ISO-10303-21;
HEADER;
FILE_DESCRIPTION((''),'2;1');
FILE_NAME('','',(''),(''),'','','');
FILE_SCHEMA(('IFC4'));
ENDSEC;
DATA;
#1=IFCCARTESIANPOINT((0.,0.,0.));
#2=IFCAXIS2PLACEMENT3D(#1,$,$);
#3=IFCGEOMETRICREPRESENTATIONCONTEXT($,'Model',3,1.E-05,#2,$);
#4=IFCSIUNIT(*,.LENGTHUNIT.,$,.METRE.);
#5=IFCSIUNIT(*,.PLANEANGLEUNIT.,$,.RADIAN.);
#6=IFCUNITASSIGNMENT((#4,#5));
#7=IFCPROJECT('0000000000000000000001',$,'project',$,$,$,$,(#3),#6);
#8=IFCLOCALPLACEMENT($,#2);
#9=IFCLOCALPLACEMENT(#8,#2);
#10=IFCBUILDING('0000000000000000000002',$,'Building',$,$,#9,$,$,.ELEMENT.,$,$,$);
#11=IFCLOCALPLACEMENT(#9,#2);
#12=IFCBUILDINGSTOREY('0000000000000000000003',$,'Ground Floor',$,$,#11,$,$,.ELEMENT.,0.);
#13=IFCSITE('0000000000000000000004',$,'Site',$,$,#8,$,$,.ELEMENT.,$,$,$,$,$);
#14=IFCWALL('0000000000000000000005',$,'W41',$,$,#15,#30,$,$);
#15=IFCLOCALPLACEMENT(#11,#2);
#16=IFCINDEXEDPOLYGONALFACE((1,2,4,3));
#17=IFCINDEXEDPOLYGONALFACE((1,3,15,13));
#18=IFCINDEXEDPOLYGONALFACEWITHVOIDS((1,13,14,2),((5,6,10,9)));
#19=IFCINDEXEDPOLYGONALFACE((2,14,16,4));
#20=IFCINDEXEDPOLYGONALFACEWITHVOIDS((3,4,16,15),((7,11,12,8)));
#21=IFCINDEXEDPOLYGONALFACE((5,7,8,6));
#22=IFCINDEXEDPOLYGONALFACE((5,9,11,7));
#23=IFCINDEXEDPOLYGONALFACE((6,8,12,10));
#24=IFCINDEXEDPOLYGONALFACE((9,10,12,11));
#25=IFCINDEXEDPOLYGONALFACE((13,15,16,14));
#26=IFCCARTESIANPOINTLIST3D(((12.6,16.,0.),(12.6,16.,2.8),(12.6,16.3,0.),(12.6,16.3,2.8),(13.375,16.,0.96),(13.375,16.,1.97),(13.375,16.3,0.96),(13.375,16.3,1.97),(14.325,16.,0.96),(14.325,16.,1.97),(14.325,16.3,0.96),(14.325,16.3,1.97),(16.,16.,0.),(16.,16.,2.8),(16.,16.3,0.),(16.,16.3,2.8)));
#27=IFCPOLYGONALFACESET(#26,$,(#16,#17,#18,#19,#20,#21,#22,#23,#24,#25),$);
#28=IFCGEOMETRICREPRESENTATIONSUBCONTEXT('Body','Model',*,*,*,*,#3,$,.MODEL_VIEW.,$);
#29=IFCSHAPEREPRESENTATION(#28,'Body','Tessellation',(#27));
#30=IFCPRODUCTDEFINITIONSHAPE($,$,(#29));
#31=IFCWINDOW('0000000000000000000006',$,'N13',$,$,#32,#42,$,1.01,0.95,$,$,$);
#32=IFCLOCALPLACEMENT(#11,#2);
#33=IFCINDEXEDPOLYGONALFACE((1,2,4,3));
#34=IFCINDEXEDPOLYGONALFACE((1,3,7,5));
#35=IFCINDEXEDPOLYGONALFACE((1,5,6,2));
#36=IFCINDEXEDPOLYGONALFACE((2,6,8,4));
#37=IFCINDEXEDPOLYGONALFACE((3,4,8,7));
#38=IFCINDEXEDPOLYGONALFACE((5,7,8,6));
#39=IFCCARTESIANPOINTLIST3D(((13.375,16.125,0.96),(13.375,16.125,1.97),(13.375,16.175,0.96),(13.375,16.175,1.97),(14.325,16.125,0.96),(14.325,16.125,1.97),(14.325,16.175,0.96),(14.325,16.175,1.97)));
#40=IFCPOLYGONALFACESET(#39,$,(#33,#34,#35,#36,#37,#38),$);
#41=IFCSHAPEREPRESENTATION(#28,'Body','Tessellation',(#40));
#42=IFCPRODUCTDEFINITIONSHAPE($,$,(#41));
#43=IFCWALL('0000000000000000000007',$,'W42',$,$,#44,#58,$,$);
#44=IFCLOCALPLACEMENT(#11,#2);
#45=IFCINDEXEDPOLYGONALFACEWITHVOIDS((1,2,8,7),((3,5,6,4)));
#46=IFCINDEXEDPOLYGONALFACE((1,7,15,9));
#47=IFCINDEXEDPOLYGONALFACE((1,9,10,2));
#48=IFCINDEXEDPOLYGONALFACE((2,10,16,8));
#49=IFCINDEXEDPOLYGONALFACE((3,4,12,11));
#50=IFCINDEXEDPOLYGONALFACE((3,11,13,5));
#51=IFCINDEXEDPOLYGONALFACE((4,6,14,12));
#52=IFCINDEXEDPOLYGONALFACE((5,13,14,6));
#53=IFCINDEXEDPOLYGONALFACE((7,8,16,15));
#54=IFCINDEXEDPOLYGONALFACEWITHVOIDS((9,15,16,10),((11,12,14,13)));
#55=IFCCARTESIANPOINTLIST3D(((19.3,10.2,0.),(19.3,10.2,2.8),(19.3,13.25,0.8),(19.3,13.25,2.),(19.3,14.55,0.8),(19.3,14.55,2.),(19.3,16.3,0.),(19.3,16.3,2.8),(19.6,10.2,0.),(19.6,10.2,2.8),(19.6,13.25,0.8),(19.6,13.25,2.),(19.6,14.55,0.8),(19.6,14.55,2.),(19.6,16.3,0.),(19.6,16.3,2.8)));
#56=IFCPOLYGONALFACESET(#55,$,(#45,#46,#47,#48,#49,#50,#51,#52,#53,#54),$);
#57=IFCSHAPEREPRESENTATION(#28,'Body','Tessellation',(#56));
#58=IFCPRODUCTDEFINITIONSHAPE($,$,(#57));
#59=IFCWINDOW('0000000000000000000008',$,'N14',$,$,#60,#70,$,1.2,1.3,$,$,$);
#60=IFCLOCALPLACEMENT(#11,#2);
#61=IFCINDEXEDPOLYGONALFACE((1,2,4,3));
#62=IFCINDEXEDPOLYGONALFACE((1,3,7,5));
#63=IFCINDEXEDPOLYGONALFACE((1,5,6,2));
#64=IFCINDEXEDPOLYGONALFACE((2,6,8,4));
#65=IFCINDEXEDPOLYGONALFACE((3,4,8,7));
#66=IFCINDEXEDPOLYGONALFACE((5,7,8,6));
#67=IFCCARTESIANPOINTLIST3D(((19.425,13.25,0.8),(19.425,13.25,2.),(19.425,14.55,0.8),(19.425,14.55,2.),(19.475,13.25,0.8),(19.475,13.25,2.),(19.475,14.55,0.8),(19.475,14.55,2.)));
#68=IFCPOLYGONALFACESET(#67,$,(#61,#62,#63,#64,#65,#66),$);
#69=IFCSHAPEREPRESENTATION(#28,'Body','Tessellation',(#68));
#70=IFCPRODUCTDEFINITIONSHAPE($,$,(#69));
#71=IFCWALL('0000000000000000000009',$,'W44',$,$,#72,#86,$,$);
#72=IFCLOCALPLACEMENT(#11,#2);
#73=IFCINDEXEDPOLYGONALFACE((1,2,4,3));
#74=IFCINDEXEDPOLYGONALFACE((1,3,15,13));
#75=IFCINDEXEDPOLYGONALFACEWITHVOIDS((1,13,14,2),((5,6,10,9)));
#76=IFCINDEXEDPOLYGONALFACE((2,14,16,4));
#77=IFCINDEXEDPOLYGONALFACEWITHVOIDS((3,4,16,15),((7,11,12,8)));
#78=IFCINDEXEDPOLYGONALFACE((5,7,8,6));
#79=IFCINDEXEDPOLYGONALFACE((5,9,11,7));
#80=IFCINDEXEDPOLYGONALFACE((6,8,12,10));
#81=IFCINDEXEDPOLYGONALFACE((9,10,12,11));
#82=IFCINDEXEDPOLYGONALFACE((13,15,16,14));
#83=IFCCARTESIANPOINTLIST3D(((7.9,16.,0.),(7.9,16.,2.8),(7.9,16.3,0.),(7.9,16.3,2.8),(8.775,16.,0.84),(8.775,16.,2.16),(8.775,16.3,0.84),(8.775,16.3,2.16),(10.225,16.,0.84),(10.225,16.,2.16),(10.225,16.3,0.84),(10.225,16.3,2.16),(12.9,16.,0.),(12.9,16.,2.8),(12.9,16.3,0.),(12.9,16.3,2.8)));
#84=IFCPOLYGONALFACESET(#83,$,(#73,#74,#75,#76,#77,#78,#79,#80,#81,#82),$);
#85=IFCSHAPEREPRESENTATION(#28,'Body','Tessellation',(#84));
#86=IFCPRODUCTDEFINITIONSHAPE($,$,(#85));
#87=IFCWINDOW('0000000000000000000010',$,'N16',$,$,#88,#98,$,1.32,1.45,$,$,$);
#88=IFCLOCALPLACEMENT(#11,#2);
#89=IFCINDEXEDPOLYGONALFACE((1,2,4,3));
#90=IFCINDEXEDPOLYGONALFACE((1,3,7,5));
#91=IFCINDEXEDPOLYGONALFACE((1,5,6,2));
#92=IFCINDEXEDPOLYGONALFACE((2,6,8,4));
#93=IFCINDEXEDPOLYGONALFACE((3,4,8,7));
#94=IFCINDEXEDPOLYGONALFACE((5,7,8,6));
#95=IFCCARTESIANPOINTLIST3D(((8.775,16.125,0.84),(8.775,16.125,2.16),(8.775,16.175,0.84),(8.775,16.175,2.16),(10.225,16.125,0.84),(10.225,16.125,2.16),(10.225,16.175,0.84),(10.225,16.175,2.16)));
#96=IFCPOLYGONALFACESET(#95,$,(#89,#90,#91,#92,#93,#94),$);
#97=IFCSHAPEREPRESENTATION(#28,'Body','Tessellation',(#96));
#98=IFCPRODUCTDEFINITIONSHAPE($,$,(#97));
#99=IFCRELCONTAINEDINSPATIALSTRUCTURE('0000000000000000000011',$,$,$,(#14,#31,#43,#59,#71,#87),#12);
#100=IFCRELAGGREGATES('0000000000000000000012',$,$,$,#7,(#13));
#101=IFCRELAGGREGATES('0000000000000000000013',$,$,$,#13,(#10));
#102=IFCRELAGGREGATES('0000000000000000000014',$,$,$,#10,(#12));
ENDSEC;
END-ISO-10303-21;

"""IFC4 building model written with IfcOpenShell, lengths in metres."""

from ifc_helpers import new_model, si_unit, frame, frame_2d, origin, origin_2d, place, context, subcontext, project, spatial, rectangle, extrude, element, fill, save


model = new_model("IFC4")

# Units and contexts
model_context = context("Model", 3, precision=1e-05, world=origin())
body_context = subcontext(model_context, "Body", "Model", "MODEL_VIEW")
ifc_project = project(units=[si_unit("LENGTHUNIT", "METRE"), si_unit("PLANEANGLEUNIT", "RADIAN")], contexts=[model_context])

# Site, building, storey
site_placement = place(None, origin())
site = spatial("IfcSite", under=ifc_project, at=site_placement, Name="Site", CompositionType="ELEMENT")
building_placement = place(site_placement, origin())
building = spatial("IfcBuilding", under=site, at=building_placement, Name="Building", CompositionType="ELEMENT")
storey_placement = place(building_placement, origin())
storey = spatial("IfcBuildingStorey", under=building, at=storey_placement, Name="Ground Floor", CompositionType="ELEMENT", Elevation=0.0)

# Walls, openings, windows
wall_1_placement = place(storey_placement, frame((12.75, 16.15, 0.0), x_axis=(1.0, 0.0, 0.0)))
wall_1 = element("IfcWall", 1, at=wall_1_placement, inside=storey, Name="W41", context=body_context, shape_type="SweptSolid", body=[
    extrude(rectangle(XDim=3.4, YDim=0.3, at=frame_2d((1.55, 0.0))), origin(), (0.0, 0.0, 1.0), 2.8),
])
opening_1_placement = place(wall_1_placement, frame((1.1, 0.0, 0.96)))
opening_1 = element("IfcOpeningElement", 2, at=opening_1_placement, cuts=wall_1, context=body_context, shape_type="SweptSolid", body=[
    extrude(rectangle(XDim=0.95, YDim=0.4, at=origin_2d()), origin(), (0.0, 0.0, 1.0), 1.01),
])
window_1_placement = place(opening_1_placement, origin())
window_1 = element("IfcWindow", 3, at=window_1_placement, inside=storey, Name="N13", OverallHeight=1.01, OverallWidth=0.95, context=body_context, shape_type="SweptSolid", body=[
    extrude(rectangle(XDim=0.95, YDim=0.05, at=origin_2d()), origin(), (0.0, 0.0, 1.0), 1.01),
])
fill(opening_1, window_1)
wall_2_placement = place(storey_placement, frame((19.45, 10.35, 0.0), x_axis=(0.0, 1.0, 0.0)))
wall_2 = element("IfcWall", 4, at=wall_2_placement, inside=storey, Name="W42", context=body_context, shape_type="SweptSolid", body=[
    extrude(rectangle(XDim=6.1, YDim=0.3, at=frame_2d((2.9, 0.0))), origin(), (0.0, 0.0, 1.0), 2.8),
])
opening_2_placement = place(wall_2_placement, frame((3.55, 0.0, 0.8)))
opening_2 = element("IfcOpeningElement", 5, at=opening_2_placement, cuts=wall_2, context=body_context, shape_type="SweptSolid", body=[
    extrude(rectangle(XDim=1.3, YDim=0.4, at=origin_2d()), origin(), (0.0, 0.0, 1.0), 1.2),
])
window_2_placement = place(opening_2_placement, origin())
window_2 = element("IfcWindow", 6, at=window_2_placement, inside=storey, Name="N14", OverallHeight=1.2, OverallWidth=1.3, context=body_context, shape_type="SweptSolid", body=[
    extrude(rectangle(XDim=1.3, YDim=0.05, at=origin_2d()), origin(), (0.0, 0.0, 1.0), 1.2),
])
fill(opening_2, window_2)
wall_3_placement = place(storey_placement, frame((8.05, 16.15, 0.0), x_axis=(1.0, 0.0, 0.0)))
wall_3 = element("IfcWall", 7, at=wall_3_placement, inside=storey, Name="W44", context=body_context, shape_type="SweptSolid", body=[
    extrude(rectangle(XDim=5.0, YDim=0.3, at=frame_2d((2.35, 0.0))), origin(), (0.0, 0.0, 1.0), 2.8),
])
opening_3_placement = place(wall_3_placement, frame((1.45, 0.0, 0.84)))
opening_3 = element("IfcOpeningElement", 8, at=opening_3_placement, cuts=wall_3, context=body_context, shape_type="SweptSolid", body=[
    extrude(rectangle(XDim=1.45, YDim=0.4, at=origin_2d()), origin(), (0.0, 0.0, 1.0), 1.32),
])
window_3_placement = place(opening_3_placement, origin())
window_3 = element("IfcWindow", 9, at=window_3_placement, inside=storey, Name="N16", OverallHeight=1.32, OverallWidth=1.45, context=body_context, shape_type="SweptSolid", body=[
    extrude(rectangle(XDim=1.45, YDim=0.05, at=origin_2d()), origin(), (0.0, 0.0, 1.0), 1.32),
])
fill(opening_3, window_3)

save(model, "model.ifc")
